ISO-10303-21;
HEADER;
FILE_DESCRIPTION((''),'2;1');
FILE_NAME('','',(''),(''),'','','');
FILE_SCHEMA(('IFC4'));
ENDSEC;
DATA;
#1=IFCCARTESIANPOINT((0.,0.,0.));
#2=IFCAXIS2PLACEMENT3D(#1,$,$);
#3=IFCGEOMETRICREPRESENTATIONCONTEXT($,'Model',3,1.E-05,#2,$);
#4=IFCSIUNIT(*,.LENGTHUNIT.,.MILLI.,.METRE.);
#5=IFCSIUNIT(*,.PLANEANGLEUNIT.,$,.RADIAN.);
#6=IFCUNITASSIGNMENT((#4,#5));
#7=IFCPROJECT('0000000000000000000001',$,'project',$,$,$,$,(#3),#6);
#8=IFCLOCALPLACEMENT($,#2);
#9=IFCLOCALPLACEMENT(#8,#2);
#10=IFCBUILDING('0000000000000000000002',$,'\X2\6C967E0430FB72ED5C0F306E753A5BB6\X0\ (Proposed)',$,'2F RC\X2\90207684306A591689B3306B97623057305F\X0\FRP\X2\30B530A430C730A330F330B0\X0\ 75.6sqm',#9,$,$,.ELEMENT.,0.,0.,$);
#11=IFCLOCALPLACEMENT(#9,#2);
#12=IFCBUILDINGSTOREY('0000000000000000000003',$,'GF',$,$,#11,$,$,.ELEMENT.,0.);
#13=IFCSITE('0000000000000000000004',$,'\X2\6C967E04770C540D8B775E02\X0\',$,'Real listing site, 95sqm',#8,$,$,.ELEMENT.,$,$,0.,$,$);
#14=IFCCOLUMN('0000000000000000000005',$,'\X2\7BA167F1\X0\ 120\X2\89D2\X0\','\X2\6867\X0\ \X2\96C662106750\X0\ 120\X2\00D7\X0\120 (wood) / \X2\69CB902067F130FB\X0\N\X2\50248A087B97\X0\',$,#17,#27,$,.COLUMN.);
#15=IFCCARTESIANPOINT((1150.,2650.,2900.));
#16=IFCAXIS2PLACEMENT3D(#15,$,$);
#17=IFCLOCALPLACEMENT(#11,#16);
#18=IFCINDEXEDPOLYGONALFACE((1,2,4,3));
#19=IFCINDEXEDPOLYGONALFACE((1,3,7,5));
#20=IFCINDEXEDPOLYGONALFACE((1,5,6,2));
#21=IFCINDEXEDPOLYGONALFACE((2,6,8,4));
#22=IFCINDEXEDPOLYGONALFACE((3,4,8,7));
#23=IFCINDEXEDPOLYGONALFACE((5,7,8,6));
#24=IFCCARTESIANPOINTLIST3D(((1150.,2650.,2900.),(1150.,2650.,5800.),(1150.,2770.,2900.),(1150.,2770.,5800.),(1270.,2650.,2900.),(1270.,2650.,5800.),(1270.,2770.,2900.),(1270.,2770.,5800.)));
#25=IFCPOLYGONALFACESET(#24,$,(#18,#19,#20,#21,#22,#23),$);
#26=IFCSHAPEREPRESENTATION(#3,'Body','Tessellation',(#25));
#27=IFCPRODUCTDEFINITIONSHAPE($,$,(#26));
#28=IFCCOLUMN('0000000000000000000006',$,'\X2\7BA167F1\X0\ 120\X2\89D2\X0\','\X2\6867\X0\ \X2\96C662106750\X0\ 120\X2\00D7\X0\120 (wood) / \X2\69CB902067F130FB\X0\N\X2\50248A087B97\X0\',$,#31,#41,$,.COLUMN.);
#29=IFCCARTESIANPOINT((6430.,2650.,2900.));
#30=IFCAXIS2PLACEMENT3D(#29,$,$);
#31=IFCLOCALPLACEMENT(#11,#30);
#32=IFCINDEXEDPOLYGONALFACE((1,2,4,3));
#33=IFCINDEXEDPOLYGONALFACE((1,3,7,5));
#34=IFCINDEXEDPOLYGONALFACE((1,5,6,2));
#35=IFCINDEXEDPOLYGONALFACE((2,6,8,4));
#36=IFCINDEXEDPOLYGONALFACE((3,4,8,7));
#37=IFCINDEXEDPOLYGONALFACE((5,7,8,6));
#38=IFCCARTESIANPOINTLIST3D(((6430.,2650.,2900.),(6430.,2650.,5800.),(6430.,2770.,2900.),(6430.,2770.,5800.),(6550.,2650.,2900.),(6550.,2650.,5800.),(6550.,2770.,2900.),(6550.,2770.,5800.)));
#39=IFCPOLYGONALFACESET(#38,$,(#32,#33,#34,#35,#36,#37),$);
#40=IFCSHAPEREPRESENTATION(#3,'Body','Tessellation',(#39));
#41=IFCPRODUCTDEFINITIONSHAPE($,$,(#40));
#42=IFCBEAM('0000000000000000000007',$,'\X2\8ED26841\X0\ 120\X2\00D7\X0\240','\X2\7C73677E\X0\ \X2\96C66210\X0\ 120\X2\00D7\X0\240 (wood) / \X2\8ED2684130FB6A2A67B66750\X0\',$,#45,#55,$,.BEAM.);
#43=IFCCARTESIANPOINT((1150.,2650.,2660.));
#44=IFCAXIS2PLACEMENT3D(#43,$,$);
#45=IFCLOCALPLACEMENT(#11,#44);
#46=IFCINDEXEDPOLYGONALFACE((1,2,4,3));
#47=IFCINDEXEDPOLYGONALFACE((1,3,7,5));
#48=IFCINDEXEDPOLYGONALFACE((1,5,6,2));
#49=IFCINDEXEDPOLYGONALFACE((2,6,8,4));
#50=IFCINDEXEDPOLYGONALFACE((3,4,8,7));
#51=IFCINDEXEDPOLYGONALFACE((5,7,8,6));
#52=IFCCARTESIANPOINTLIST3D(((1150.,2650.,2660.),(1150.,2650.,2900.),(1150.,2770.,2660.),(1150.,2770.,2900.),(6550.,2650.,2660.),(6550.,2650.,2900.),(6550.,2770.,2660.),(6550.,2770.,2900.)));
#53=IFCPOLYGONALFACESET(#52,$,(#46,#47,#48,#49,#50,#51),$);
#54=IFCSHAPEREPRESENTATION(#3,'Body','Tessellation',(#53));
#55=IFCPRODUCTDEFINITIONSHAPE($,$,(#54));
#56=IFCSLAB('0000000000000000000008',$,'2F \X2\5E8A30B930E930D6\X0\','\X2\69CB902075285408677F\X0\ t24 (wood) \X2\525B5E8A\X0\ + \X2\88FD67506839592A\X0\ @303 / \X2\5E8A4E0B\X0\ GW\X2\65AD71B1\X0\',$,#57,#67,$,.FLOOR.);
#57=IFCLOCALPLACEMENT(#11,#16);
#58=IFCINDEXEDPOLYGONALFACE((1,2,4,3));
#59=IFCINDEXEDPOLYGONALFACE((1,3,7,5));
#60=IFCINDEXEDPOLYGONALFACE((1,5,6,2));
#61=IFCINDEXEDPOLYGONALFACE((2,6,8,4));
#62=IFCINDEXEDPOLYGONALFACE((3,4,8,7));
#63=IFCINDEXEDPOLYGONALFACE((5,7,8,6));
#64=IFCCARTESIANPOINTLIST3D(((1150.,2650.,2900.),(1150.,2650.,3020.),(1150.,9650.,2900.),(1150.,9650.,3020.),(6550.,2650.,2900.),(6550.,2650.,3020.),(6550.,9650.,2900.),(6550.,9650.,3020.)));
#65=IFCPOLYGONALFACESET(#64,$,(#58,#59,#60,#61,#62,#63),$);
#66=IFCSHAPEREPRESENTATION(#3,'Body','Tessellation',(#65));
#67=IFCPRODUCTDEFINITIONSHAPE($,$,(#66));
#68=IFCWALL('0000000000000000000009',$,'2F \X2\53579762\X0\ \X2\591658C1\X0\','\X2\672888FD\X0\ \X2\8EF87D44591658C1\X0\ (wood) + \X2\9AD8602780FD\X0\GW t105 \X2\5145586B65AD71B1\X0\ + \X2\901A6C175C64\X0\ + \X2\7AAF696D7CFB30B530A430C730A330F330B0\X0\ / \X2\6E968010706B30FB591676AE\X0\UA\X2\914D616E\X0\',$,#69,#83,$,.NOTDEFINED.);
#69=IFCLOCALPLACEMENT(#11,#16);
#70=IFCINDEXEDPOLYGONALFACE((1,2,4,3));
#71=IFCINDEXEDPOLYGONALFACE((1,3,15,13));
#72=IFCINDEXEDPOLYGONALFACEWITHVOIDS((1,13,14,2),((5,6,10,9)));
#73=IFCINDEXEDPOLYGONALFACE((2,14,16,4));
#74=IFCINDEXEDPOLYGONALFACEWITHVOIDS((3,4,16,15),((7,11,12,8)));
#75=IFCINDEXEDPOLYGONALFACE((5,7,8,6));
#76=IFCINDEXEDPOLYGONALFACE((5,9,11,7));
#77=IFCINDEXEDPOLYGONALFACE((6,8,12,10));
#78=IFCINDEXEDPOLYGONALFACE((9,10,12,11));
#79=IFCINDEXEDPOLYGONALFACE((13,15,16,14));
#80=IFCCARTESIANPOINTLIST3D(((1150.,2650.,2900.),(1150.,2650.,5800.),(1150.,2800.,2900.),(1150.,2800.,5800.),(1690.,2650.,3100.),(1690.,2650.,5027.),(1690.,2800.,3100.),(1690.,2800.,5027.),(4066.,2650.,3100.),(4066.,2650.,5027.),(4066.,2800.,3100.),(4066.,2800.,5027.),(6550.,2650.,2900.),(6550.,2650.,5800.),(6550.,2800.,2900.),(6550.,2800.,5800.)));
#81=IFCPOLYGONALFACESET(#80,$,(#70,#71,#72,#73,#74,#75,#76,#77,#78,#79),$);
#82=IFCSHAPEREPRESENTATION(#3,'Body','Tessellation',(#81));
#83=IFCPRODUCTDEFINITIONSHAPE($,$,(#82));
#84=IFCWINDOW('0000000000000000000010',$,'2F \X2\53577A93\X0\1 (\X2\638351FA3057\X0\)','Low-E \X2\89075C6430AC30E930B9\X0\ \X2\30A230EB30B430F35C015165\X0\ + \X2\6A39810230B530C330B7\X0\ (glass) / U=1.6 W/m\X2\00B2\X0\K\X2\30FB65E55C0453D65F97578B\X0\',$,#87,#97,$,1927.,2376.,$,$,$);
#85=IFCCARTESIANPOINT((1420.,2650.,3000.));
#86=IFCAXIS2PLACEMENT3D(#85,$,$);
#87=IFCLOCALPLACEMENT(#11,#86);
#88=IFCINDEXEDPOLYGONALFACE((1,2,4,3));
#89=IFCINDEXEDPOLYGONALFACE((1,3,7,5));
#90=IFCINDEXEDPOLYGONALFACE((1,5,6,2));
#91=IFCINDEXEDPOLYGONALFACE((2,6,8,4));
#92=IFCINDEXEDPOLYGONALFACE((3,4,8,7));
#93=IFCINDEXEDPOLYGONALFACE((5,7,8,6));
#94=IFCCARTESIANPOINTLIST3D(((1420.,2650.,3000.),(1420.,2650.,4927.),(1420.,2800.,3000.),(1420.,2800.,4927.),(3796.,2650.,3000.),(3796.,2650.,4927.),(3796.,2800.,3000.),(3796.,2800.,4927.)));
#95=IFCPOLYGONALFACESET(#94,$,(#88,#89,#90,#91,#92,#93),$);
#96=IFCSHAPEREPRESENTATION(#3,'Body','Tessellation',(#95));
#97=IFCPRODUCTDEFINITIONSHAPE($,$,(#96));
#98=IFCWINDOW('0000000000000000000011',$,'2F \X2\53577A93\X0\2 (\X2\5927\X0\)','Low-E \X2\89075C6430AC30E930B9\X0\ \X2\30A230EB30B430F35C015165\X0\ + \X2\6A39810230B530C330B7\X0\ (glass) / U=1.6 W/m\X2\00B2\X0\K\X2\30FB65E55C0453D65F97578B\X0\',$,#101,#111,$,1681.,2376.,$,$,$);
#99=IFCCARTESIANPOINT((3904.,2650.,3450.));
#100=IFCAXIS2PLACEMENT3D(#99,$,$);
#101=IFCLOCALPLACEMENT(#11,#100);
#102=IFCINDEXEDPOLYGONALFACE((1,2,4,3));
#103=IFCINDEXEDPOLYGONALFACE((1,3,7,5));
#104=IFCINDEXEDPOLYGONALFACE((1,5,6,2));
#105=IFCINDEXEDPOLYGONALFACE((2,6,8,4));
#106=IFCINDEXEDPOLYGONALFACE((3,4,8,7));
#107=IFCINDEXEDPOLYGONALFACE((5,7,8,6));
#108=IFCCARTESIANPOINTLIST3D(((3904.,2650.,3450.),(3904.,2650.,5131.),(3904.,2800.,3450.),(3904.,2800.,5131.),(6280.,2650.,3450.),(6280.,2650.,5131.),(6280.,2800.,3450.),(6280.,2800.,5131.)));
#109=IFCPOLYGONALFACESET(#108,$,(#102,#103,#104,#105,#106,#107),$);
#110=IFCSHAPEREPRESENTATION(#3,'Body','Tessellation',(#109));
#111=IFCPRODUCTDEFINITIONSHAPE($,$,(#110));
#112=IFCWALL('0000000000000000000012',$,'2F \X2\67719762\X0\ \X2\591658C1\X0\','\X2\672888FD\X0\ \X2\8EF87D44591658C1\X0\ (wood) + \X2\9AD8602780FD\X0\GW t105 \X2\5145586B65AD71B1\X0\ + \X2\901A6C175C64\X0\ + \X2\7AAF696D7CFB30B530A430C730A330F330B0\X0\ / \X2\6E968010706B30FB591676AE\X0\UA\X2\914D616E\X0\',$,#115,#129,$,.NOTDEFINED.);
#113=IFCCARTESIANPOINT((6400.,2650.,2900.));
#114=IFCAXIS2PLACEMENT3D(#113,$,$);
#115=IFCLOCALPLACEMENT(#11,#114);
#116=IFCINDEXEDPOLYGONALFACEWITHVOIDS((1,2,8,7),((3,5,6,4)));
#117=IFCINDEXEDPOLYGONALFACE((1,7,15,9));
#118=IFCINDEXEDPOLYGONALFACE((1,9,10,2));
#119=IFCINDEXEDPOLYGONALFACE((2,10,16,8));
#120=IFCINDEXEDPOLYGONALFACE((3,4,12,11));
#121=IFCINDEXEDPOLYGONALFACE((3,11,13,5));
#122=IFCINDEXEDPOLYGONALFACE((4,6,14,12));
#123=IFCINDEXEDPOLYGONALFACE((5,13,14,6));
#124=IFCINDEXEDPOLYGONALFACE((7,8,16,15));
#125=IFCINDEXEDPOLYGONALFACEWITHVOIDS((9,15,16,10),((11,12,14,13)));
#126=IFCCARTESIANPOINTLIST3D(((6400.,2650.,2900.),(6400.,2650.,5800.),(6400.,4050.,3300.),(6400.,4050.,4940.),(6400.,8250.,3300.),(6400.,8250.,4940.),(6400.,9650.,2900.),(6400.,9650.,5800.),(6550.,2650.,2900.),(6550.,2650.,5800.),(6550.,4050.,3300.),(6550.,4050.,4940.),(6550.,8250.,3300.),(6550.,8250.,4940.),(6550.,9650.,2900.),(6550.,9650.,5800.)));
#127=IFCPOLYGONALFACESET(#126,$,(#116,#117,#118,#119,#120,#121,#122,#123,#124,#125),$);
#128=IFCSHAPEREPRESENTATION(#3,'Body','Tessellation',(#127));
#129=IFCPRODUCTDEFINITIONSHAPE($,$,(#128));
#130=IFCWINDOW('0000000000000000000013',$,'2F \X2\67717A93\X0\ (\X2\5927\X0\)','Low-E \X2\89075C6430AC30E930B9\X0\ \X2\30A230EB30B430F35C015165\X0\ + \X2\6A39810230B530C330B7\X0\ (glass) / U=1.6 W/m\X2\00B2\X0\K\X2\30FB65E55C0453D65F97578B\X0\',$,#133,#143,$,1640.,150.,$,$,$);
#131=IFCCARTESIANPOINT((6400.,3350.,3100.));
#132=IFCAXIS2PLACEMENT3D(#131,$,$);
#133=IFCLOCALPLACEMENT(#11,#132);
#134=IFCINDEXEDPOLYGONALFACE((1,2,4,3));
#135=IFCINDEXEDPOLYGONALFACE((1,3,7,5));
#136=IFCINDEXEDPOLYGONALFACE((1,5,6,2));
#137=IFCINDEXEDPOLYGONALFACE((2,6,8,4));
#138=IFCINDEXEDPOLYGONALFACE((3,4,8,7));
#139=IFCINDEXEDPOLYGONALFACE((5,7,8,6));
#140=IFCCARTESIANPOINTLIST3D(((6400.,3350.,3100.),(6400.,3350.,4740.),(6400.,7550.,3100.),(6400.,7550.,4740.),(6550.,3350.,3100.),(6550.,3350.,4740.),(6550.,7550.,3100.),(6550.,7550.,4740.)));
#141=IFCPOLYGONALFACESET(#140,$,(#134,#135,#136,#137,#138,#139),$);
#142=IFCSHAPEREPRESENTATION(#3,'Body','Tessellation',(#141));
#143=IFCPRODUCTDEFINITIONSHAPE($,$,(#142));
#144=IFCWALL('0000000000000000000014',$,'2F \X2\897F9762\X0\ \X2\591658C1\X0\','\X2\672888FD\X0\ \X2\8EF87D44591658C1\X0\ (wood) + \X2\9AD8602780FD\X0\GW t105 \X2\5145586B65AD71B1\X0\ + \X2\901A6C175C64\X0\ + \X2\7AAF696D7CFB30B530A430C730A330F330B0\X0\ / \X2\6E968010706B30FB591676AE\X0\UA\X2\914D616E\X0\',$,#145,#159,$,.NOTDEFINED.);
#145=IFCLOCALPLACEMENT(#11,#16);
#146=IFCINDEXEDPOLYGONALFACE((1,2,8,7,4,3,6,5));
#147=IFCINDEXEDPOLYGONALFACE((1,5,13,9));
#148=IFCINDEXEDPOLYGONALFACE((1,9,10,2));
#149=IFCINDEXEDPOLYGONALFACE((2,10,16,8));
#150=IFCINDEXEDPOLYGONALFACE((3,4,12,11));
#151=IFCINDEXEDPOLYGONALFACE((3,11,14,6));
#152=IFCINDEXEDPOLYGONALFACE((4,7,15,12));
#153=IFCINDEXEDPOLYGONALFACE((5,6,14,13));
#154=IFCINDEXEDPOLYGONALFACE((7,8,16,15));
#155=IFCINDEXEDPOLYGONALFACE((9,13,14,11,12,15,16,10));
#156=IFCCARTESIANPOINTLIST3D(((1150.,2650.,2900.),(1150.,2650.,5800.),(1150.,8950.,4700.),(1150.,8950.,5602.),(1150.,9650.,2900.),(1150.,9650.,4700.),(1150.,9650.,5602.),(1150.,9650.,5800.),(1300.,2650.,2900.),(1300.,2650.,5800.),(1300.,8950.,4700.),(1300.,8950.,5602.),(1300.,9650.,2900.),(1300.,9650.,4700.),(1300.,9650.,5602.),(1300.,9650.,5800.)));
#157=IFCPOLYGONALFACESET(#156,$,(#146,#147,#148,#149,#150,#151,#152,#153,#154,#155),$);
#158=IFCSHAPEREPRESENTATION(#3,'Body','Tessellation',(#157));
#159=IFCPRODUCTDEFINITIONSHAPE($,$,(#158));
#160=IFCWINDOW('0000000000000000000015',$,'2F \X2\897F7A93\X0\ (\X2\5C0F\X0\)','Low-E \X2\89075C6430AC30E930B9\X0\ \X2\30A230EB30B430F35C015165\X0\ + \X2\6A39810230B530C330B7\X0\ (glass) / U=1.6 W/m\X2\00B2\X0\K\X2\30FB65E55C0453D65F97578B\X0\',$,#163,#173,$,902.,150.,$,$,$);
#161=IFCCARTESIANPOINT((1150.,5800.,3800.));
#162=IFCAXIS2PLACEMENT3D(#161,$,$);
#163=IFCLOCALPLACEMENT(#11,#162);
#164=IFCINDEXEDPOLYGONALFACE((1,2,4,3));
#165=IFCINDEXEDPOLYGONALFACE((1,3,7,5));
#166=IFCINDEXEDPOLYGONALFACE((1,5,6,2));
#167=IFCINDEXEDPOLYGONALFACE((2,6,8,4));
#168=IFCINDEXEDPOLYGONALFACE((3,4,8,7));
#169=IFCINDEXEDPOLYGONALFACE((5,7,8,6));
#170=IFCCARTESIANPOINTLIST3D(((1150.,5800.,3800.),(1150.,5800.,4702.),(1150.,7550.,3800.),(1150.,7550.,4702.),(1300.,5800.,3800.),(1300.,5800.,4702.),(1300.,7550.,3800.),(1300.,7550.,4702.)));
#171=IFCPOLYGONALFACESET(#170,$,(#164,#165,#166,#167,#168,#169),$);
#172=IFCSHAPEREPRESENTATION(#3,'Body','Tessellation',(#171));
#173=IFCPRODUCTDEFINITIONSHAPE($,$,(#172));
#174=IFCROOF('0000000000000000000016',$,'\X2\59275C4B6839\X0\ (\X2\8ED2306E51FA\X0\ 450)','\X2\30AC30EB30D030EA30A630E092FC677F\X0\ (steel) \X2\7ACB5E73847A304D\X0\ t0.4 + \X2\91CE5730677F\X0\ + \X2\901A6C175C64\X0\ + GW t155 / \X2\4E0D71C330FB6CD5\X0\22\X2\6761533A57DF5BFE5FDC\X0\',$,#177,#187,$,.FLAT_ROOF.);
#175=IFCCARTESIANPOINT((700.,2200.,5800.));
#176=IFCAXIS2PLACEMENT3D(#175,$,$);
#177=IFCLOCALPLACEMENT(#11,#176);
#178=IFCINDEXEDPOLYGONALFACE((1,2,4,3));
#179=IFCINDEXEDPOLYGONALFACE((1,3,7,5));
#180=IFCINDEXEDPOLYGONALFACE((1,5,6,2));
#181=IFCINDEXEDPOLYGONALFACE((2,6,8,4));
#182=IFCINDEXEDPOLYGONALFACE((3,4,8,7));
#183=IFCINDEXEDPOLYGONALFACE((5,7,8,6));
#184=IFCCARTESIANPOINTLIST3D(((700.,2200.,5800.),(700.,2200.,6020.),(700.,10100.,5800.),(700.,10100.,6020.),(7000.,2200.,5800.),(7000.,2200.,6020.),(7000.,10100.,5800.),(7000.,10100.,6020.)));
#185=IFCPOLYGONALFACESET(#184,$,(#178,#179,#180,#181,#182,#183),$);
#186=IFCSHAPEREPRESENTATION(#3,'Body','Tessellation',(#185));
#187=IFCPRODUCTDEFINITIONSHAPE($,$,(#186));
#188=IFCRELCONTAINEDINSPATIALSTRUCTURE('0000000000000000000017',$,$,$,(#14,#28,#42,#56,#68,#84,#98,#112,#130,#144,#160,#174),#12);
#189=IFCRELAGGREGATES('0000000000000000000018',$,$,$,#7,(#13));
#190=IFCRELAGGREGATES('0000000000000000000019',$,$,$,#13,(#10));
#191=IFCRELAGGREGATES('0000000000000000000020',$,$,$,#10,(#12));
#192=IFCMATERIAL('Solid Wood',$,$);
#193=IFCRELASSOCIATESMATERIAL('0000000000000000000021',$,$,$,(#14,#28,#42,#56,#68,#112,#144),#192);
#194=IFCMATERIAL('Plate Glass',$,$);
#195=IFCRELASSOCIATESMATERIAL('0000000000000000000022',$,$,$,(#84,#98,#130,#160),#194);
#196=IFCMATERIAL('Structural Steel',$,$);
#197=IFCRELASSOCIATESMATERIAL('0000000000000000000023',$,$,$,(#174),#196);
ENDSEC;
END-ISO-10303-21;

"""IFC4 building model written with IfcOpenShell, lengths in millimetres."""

from ifc_helpers import new_model, si_unit, frame, frame_2d, origin, place, context, project, spatial, rectangle, extrude, material, element, fill, save


model = new_model("IFC4")

# Units and contexts
model_context = context("Model", 3, precision=1e-05, world=origin())
ifc_project = project(units=[si_unit("LENGTHUNIT", "METRE", prefix="MILLI"), si_unit("PLANEANGLEUNIT", "RADIAN")], contexts=[model_context])

# Site, building, storey
site_placement = place(None, origin())
site = spatial("IfcSite", under=ifc_project, at=site_placement, Name="沖縄県名護市", ObjectType="Real listing site, 95sqm", CompositionType="ELEMENT", RefElevation=0.0)
building_placement = place(site_placement, origin())
building = spatial("IfcBuilding", under=site, at=building_placement, Name="沖縄・狭小の町家 (Proposed)", ObjectType="2F RC造的な外観に面したFRPサイディング 75.6sqm", CompositionType="ELEMENT", ElevationOfRefHeight=0.0, ElevationOfTerrain=0.0)
storey_placement = place(building_placement, origin())
storey = spatial("IfcBuildingStorey", under=building, at=storey_placement, Name="GF", CompositionType="ELEMENT", Elevation=0.0)

# Columns
ifc_material_1 = material(Name="Solid Wood")
column_1_placement = place(storey_placement, frame((1150.0, 2650.0, 2900.0)))
element("IfcColumn", 1, at=column_1_placement, inside=storey, material=ifc_material_1, Name="管柱 120角", Description="桧 集成材 120×120 (wood) / 構造柱・N値計算", PredefinedType="COLUMN", context=model_context, shape_type="SweptSolid", body=[
    extrude(rectangle(XDim=120.0, YDim=120.0, at=frame_2d((60.0, 60.0))), frame((1150.0, 2650.0, 2900.0)), (0.0, 0.0, 1.0), 2900.0),
])
column_2_placement = place(storey_placement, frame((6430.0, 2650.0, 2900.0)))
element("IfcColumn", 2, at=column_2_placement, inside=storey, material=ifc_material_1, Name="管柱 120角", Description="桧 集成材 120×120 (wood) / 構造柱・N値計算", PredefinedType="COLUMN", context=model_context, shape_type="SweptSolid", body=[
    extrude(rectangle(XDim=120.0, YDim=120.0, at=frame_2d((60.0, 60.0))), frame((6430.0, 2650.0, 2900.0)), (0.0, 0.0, 1.0), 2900.0),
])

# Beam
beam_1_placement = place(storey_placement, frame((1150.0, 2650.0, 2660.0)))
element("IfcBeam", 3, at=beam_1_placement, inside=storey, material=ifc_material_1, Name="軒桁 120×240", Description="米松 集成 120×240 (wood) / 軒桁・横架材", PredefinedType="BEAM", context=model_context, shape_type="SweptSolid", body=[
    extrude(rectangle(XDim=5400.0, YDim=120.0, at=frame_2d((2700.0, 60.0))), frame((1150.0, 2650.0, 2660.0)), (0.0, 0.0, 1.0), 240.0),
])

# Slab
slab_placement = place(storey_placement, frame((1150.0, 2650.0, 2900.0)))
element("IfcSlab", 4, at=slab_placement, inside=storey, material=ifc_material_1, Name="2F 床スラブ", Description="構造用合板 t24 (wood) 剛床 + 製材根太 @303 / 床下 GW断熱", PredefinedType="FLOOR", context=model_context, shape_type="SweptSolid", body=[
    extrude(rectangle(XDim=5400.0, YDim=7000.0, at=frame_2d((2700.0, 3500.0))), frame((1150.0, 2650.0, 2900.0)), (0.0, 0.0, 1.0), 120.0),
])

# Wall, openings, windows
wall_1_placement = place(storey_placement, frame((1150.0, 2650.0, 2900.0)))
wall_1 = element("IfcWall", 5, at=wall_1_placement, inside=storey, material=ifc_material_1, Name="2F 南面 外壁", Description="木製 軸組外壁 (wood) + 高性能GW t105 充填断熱 + 通気層 + 窯業系サイディング / 準耐火・外皮UA配慮", PredefinedType="NOTDEFINED", context=model_context, shape_type="SweptSolid", body=[
    extrude(rectangle(XDim=5400.0, YDim=150.0, at=frame_2d((2700.0, 75.0))), frame((1150.0, 2650.0, 2900.0)), (0.0, 0.0, 1.0), 2900.0),
])
opening_1_placement = place(storey_placement, frame((1420.0, 2650.0, 3000.0)))
opening_1 = element("IfcOpeningElement", 6, at=opening_1_placement, cuts=wall_1, PredefinedType="NOTDEFINED", context=model_context, shape_type="SweptSolid", body=[
    extrude(rectangle(XDim=2376.0, YDim=150.0, at=frame_2d((1188.0, 75.0))), frame((1420.0, 2650.0, 3000.0)), (0.0, 0.0, 1.0), 1927.0),
])
opening_2_placement = place(storey_placement, frame((3904.0, 2650.0, 3450.0)))
opening_2 = element("IfcOpeningElement", 7, at=opening_2_placement, cuts=wall_1, PredefinedType="NOTDEFINED", context=model_context, shape_type="SweptSolid", body=[
    extrude(rectangle(XDim=2376.0, YDim=150.0, at=frame_2d((1188.0, 75.0))), frame((3904.0, 2650.0, 3450.0)), (0.0, 0.0, 1.0), 1681.0),
])
ifc_material_2 = material(Name="Plate Glass")
window_1_placement = place(storey_placement, frame((1420.0, 2650.0, 3000.0)))
window_1 = element("IfcWindow", 8, at=window_1_placement, inside=storey, material=ifc_material_2, Name="2F 南窓1 (掃出し)", Description="Low-E 複層ガラス アルゴン封入 + 樹脂サッシ (glass) / U=1.6 W/m²K・日射取得型", OverallHeight=1927.0, OverallWidth=2376.0, context=model_context, shape_type="SweptSolid", body=[
    extrude(rectangle(XDim=2376.0, YDim=150.0, at=frame_2d((1188.0, 75.0))), frame((1420.0, 2650.0, 3000.0)), (0.0, 0.0, 1.0), 1927.0),
])
fill(opening_1, window_1)
window_2_placement = place(storey_placement, frame((3904.0, 2650.0, 3450.0)))
window_2 = element("IfcWindow", 9, at=window_2_placement, inside=storey, material=ifc_material_2, Name="2F 南窓2 (大)", Description="Low-E 複層ガラス アルゴン封入 + 樹脂サッシ (glass) / U=1.6 W/m²K・日射取得型", OverallHeight=1681.0, OverallWidth=2376.0, context=model_context, shape_type="SweptSolid", body=[
    extrude(rectangle(XDim=2376.0, YDim=150.0, at=frame_2d((1188.0, 75.0))), frame((3904.0, 2650.0, 3450.0)), (0.0, 0.0, 1.0), 1681.0),
])
fill(opening_2, window_2)

# Walls, openings, windows
wall_2_placement = place(storey_placement, frame((6400.0, 2650.0, 2900.0)))
wall_2 = element("IfcWall", 10, at=wall_2_placement, inside=storey, material=ifc_material_1, Name="2F 東面 外壁", Description="木製 軸組外壁 (wood) + 高性能GW t105 充填断熱 + 通気層 + 窯業系サイディング / 準耐火・外皮UA配慮", PredefinedType="NOTDEFINED", context=model_context, shape_type="SweptSolid", body=[
    extrude(rectangle(XDim=150.0, YDim=7000.0, at=frame_2d((75.0, 3500.0))), frame((6400.0, 2650.0, 2900.0)), (0.0, 0.0, 1.0), 2900.0),
])
opening_3_placement = place(storey_placement, frame((6400.0, 3350.0, 3100.0)))
opening_3 = element("IfcOpeningElement", 11, at=opening_3_placement, cuts=wall_2, PredefinedType="NOTDEFINED", context=model_context, shape_type="SweptSolid", body=[
    extrude(rectangle(XDim=150.0, YDim=4200.0, at=frame_2d((75.0, 2100.0))), frame((6400.0, 3350.0, 3100.0)), (0.0, 0.0, 1.0), 1640.0),
])
window_3_placement = place(storey_placement, frame((6400.0, 3350.0, 3100.0)))
window_3 = element("IfcWindow", 12, at=window_3_placement, inside=storey, material=ifc_material_2, Name="2F 東窓 (大)", Description="Low-E 複層ガラス アルゴン封入 + 樹脂サッシ (glass) / U=1.6 W/m²K・日射取得型", OverallHeight=1640.0, OverallWidth=150.0, context=model_context, shape_type="SweptSolid", body=[
    extrude(rectangle(XDim=150.0, YDim=4200.0, at=frame_2d((75.0, 2100.0))), frame((6400.0, 3350.0, 3100.0)), (0.0, 0.0, 1.0), 1640.0),
])
fill(opening_3, window_3)
wall_3_placement = place(storey_placement, frame((1150.0, 2650.0, 2900.0)))
wall_3 = element("IfcWall", 13, at=wall_3_placement, inside=storey, material=ifc_material_1, Name="2F 西面 外壁", Description="木製 軸組外壁 (wood) + 高性能GW t105 充填断熱 + 通気層 + 窯業系サイディング / 準耐火・外皮UA配慮", PredefinedType="NOTDEFINED", context=model_context, shape_type="SweptSolid", body=[
    extrude(rectangle(XDim=150.0, YDim=7000.0, at=frame_2d((75.0, 3500.0))), frame((1150.0, 2650.0, 2900.0)), (0.0, 0.0, 1.0), 2900.0),
])
opening_4_placement = place(storey_placement, frame((1150.0, 5800.0, 3800.0)))
opening_4 = element("IfcOpeningElement", 14, at=opening_4_placement, cuts=wall_3, PredefinedType="NOTDEFINED", context=model_context, shape_type="SweptSolid", body=[
    extrude(rectangle(XDim=150.0, YDim=1750.0, at=frame_2d((75.0, 875.0))), frame((1150.0, 5800.0, 3800.0)), (0.0, 0.0, 1.0), 902.0),
])
window_4_placement = place(storey_placement, frame((1150.0, 5800.0, 3800.0)))
window_4 = element("IfcWindow", 15, at=window_4_placement, inside=storey, material=ifc_material_2, Name="2F 西窓 (小)", Description="Low-E 複層ガラス アルゴン封入 + 樹脂サッシ (glass) / U=1.6 W/m²K・日射取得型", OverallHeight=902.0, OverallWidth=150.0, context=model_context, shape_type="SweptSolid", body=[
    extrude(rectangle(XDim=150.0, YDim=1750.0, at=frame_2d((75.0, 875.0))), frame((1150.0, 5800.0, 3800.0)), (0.0, 0.0, 1.0), 902.0),
])
fill(opening_4, window_4)

# Roof
ifc_material_3 = material(Name="Structural Steel")
roof_placement = place(storey_placement, frame((700.0, 2200.0, 5800.0)))
element("IfcRoof", 16, at=roof_placement, inside=storey, material=ifc_material_3, Name="大屋根 (軒の出 450)", Description="ガルバリウム鋼板 (steel) 立平葺き t0.4 + 野地板 + 通気層 + GW t155 / 不燃・法22条区域対応", PredefinedType="FLAT_ROOF", context=model_context, shape_type="SweptSolid", body=[
    extrude(rectangle(XDim=6300.0, YDim=7900.0, at=frame_2d((3150.0, 3950.0))), frame((700.0, 2200.0, 5800.0)), (0.0, 0.0, 1.0), 220.0),
])

save(model, "model.ifc")
